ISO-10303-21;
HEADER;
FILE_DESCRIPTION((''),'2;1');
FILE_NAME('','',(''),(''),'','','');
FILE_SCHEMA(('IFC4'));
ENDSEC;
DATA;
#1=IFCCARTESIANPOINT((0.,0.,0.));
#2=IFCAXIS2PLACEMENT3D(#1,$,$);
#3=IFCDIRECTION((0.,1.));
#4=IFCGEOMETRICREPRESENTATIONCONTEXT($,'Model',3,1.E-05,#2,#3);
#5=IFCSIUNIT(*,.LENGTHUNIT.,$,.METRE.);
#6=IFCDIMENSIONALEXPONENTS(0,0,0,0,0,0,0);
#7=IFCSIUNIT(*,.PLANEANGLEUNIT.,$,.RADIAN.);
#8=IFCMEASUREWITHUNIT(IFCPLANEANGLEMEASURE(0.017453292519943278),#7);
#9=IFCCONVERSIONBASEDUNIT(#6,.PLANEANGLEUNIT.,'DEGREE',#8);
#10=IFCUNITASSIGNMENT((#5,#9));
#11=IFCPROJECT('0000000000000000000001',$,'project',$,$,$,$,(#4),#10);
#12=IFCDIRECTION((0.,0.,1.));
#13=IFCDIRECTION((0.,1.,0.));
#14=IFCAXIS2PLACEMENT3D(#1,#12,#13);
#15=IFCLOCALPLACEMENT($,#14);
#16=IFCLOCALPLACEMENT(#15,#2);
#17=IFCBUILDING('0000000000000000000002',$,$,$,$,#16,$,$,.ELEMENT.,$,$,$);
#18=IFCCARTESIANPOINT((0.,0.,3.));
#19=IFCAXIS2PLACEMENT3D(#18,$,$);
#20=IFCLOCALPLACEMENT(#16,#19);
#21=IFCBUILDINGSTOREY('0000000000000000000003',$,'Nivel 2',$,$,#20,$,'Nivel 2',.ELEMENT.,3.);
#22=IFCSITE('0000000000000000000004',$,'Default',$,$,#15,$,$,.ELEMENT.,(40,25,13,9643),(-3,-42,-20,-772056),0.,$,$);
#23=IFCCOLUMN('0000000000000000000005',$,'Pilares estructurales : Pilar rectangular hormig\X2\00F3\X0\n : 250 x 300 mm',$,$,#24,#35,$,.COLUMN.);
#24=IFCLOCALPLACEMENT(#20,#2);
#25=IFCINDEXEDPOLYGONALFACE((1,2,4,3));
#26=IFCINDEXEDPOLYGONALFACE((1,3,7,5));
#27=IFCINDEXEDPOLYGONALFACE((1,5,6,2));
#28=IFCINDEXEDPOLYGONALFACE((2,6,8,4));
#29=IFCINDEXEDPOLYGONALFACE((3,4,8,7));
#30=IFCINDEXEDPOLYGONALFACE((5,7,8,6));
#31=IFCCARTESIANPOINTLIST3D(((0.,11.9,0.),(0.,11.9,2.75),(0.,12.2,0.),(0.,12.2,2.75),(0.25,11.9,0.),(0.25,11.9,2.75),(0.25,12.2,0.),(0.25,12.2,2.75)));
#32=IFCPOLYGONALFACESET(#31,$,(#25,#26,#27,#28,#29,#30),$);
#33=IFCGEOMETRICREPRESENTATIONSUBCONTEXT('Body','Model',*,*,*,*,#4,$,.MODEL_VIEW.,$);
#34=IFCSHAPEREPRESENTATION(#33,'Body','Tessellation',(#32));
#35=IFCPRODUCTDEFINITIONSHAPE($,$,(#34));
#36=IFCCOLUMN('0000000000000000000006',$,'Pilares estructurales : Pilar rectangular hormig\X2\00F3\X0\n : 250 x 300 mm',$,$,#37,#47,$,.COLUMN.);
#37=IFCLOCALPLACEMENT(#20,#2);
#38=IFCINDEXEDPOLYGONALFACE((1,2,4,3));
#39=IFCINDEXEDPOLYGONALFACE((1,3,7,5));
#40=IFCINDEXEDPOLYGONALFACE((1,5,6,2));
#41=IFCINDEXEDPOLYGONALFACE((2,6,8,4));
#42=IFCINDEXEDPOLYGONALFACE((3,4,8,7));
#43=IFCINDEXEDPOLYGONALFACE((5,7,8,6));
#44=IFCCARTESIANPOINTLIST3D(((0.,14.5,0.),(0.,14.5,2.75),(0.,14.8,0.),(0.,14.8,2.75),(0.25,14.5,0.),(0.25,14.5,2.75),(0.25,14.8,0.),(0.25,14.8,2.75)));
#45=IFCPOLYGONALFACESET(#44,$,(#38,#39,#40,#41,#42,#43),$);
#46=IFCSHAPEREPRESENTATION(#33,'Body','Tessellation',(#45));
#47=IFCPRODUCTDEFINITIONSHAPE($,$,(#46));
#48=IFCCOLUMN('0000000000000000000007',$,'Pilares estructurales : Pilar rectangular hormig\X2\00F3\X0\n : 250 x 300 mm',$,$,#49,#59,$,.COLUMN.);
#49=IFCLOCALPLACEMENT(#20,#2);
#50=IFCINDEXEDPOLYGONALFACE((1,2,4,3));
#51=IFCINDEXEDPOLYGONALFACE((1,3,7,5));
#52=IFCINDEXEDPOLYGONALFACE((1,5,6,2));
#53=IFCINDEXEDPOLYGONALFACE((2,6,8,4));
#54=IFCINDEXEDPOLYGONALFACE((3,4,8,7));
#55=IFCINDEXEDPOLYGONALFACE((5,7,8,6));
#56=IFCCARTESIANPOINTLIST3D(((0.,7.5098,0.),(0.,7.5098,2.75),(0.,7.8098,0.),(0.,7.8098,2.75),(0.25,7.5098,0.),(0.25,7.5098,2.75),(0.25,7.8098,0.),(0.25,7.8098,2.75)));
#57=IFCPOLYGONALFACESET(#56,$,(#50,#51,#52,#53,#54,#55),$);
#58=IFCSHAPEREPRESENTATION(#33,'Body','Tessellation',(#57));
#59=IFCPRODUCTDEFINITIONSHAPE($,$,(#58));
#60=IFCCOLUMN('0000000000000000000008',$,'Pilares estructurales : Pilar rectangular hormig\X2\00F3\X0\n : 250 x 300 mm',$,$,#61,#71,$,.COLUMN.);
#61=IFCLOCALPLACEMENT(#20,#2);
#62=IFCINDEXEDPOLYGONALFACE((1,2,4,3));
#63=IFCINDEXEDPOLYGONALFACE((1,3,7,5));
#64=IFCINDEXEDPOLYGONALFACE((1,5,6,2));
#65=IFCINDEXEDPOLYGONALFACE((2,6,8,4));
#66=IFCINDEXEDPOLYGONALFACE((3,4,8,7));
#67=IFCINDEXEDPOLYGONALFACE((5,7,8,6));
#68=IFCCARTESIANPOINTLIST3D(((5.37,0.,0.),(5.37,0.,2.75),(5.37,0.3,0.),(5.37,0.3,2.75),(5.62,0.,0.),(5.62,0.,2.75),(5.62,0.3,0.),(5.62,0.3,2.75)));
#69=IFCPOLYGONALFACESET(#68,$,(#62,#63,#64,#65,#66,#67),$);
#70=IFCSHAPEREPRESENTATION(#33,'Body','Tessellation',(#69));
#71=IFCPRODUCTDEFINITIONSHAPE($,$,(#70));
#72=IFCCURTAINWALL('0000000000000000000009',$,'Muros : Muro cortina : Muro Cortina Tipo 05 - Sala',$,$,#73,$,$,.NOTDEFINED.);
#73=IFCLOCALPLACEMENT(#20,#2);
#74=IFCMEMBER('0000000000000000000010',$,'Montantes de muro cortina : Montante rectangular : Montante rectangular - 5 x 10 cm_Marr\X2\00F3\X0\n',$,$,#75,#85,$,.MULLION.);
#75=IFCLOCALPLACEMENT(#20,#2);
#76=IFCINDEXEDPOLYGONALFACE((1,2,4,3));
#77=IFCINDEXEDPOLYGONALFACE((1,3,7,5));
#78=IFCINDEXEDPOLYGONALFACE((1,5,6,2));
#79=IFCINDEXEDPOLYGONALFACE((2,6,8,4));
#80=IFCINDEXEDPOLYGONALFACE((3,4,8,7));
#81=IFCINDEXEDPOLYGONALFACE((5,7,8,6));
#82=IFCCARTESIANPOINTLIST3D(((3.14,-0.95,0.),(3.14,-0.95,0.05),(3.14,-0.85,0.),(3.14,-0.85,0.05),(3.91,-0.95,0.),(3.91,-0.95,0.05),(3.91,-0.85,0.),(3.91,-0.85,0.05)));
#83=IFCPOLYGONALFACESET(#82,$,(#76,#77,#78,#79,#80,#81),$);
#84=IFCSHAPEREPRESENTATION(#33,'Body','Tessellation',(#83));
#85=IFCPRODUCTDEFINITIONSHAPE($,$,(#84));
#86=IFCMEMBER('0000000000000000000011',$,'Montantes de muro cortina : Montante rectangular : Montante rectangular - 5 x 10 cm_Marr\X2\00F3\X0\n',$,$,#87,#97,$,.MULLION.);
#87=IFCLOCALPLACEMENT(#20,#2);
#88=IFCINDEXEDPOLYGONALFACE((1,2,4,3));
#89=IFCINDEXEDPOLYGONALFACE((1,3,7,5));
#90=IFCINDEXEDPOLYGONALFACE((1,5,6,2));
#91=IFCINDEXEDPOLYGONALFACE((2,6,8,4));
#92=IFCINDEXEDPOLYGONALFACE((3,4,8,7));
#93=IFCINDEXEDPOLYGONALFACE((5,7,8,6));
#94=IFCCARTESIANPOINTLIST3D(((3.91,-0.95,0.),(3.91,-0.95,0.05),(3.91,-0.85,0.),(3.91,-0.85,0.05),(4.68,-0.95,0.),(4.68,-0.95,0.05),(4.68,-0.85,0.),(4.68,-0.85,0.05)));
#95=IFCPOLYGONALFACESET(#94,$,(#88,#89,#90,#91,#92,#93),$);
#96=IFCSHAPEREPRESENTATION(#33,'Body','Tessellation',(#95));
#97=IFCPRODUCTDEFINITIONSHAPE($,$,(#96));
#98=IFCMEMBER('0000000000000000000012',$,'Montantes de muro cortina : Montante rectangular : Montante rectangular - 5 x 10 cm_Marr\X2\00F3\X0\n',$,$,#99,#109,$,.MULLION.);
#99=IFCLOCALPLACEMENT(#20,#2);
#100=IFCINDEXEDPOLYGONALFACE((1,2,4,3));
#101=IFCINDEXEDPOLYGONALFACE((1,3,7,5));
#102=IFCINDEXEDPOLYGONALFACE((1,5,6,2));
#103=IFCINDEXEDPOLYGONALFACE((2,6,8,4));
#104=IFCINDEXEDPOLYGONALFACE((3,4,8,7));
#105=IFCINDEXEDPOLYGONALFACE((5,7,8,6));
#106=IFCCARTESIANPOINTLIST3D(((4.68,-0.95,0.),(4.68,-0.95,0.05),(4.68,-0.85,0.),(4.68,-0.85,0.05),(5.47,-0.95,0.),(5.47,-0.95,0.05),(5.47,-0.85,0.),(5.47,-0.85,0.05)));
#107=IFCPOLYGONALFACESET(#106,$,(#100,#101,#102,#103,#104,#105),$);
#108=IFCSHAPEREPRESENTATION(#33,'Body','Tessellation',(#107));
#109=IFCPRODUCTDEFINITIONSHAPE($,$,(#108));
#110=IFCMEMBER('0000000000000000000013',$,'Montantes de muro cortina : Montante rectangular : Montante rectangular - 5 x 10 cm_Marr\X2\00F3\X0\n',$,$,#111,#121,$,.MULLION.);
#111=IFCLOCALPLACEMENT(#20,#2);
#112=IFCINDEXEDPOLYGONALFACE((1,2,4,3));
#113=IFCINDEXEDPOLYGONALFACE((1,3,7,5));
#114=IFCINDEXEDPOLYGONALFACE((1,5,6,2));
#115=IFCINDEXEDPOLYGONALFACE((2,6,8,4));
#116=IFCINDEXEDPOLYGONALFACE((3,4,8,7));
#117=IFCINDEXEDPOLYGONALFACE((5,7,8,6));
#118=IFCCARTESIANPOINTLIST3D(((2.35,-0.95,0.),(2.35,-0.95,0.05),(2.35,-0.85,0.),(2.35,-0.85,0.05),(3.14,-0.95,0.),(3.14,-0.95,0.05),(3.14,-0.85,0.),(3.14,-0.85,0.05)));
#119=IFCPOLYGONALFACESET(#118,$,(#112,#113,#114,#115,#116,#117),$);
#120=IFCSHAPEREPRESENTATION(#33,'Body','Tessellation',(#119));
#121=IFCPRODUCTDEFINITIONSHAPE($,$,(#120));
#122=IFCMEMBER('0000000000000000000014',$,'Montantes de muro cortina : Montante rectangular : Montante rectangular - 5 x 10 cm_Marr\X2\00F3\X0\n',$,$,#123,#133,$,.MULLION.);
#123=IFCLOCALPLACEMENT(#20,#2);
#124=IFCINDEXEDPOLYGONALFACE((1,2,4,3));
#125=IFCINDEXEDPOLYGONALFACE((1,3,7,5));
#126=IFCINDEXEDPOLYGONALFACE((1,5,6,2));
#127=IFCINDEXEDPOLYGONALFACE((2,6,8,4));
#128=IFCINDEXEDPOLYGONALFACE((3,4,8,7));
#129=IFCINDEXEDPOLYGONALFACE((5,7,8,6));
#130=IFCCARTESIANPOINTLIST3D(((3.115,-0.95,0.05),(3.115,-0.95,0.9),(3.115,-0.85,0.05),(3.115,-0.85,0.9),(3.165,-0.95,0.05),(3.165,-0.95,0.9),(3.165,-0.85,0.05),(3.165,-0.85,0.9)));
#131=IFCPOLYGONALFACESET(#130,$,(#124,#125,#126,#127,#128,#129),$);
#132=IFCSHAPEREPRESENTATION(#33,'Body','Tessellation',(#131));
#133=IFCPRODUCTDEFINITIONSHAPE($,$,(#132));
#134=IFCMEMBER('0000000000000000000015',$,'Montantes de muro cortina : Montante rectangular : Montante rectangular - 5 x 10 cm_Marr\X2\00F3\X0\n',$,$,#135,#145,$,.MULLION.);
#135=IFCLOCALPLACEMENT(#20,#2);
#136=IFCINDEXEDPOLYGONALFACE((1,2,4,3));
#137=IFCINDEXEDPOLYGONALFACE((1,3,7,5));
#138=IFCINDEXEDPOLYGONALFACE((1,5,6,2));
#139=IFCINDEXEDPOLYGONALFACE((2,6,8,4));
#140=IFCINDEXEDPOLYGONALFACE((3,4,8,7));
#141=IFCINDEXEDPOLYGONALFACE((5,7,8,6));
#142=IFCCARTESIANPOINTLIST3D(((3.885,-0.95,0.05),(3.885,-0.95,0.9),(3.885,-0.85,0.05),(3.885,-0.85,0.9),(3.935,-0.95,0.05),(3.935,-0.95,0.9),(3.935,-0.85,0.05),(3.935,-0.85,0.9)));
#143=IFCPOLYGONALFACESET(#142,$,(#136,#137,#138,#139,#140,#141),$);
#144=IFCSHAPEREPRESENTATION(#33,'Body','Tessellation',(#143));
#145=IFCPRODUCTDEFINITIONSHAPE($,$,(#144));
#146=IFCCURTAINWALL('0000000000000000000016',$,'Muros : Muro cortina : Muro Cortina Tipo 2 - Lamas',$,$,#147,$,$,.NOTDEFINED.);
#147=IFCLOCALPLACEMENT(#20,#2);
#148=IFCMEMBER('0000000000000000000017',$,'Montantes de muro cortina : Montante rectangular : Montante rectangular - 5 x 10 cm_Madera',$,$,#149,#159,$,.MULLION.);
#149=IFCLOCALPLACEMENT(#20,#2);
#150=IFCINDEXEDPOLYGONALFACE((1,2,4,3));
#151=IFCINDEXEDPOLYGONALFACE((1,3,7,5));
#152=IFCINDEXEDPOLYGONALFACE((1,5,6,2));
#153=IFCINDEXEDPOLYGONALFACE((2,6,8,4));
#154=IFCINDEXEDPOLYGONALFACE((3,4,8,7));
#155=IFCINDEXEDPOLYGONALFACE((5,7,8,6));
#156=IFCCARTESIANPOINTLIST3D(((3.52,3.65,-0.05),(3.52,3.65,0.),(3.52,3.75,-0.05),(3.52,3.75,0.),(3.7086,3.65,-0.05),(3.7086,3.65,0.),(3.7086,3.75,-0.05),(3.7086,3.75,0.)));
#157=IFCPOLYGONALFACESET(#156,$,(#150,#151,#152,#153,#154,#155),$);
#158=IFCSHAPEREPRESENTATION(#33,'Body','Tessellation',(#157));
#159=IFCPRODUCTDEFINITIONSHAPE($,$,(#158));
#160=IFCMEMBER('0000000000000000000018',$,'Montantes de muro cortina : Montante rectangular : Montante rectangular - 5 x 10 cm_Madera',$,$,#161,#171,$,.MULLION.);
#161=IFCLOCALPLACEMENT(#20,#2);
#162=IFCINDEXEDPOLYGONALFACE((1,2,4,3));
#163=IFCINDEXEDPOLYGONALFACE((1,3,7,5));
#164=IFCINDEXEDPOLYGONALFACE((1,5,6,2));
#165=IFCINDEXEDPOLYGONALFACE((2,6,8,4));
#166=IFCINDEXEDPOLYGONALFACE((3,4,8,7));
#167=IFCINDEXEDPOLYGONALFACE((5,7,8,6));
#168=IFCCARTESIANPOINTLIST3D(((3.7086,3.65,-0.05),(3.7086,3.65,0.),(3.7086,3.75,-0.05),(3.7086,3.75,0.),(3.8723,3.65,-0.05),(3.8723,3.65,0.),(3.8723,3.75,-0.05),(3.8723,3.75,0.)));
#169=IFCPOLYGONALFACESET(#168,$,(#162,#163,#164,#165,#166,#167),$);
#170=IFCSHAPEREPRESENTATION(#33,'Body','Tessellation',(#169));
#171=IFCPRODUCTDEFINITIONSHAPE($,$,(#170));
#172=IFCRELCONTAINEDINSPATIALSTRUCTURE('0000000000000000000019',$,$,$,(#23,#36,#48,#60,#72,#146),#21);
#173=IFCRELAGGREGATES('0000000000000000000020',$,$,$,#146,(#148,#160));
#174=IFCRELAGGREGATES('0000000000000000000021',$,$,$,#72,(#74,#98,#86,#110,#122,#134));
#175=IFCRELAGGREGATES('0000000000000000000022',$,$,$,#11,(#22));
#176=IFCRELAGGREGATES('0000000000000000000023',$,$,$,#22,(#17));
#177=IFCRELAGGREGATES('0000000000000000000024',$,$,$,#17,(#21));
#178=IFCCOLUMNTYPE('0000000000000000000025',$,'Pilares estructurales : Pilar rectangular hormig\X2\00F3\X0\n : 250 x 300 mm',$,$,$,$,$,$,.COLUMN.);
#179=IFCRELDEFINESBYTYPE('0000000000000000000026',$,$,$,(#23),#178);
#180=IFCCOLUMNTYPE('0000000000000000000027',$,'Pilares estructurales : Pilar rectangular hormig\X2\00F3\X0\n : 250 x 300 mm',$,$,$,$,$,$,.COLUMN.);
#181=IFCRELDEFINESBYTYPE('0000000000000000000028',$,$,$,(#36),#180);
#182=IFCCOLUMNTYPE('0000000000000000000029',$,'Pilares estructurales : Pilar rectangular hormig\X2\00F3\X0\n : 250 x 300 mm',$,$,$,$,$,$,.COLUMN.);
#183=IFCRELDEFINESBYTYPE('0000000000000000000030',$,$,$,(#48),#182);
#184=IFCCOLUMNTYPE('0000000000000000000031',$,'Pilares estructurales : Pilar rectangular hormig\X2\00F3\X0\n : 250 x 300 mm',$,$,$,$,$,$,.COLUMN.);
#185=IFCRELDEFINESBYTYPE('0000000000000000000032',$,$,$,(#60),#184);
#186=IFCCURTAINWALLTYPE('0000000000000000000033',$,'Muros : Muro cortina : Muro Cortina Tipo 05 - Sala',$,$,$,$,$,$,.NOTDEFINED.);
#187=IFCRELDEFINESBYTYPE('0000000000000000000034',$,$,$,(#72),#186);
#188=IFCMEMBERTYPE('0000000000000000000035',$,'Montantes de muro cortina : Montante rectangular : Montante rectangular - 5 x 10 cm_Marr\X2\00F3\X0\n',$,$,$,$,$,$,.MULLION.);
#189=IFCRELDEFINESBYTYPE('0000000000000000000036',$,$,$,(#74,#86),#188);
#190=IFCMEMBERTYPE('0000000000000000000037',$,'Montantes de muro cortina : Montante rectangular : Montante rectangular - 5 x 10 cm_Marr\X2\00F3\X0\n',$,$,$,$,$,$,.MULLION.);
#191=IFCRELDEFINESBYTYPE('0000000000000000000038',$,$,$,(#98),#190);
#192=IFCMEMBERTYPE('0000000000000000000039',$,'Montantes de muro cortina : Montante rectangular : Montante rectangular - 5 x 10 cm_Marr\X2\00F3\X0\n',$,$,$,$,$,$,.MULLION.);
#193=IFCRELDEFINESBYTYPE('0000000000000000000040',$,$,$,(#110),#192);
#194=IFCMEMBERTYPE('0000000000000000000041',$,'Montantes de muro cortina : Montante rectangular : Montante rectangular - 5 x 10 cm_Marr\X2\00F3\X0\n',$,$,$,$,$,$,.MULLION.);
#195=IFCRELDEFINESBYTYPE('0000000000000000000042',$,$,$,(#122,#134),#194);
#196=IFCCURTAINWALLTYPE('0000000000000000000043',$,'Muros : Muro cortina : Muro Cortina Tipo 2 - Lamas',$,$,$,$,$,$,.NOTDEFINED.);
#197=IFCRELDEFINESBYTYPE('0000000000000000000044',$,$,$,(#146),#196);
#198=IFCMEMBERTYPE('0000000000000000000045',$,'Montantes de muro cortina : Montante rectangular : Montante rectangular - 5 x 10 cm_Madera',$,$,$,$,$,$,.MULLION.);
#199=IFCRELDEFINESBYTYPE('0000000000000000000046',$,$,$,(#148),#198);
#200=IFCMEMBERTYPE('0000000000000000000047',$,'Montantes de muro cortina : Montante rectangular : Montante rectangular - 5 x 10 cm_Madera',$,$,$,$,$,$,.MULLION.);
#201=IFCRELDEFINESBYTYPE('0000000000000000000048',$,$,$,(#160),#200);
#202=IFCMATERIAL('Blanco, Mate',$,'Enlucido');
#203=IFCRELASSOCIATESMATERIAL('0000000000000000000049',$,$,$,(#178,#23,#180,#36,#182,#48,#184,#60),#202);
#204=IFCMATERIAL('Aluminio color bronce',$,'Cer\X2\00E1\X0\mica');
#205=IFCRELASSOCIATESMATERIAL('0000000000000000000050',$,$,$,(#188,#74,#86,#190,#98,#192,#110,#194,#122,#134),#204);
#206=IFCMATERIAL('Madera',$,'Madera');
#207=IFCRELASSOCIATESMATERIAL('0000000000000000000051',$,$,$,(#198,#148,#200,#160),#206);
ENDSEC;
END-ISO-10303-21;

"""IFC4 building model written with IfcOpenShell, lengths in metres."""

from ifc_helpers import new_model, entity, si_unit, converted_unit, direction, frame, origin, place, context, subcontext, project, spatial, indexed_curve, outline, extrude, source, transform, mapped, material, type_object, type_shapes, element, aggregate, save


model = new_model("IFC4")

# Units and contexts
model_context = context("Model", 3, precision=1e-05, world=origin(), true_north=direction((0.0, 1.0)))
body_context = subcontext(model_context, "Body", "Model", "MODEL_VIEW")
ifc_project = project(units=[si_unit("LENGTHUNIT", "METRE"), converted_unit("PLANEANGLEUNIT", "DEGREE", entity("IfcPlaneAngleMeasure", 0.017453292519943278), si_unit("PLANEANGLEUNIT", "RADIAN"), dimensions=[0, 0, 0, 0, 0, 0, 0])], contexts=[model_context])

# Site, building, storey
site_placement = place(None, frame((0.0, 0.0, 0.0), z_axis=(0.0, 0.0, 1.0), x_axis=(0.0, 1.0, 0.0)))
site = spatial("IfcSite", under=ifc_project, at=site_placement, Name="Default", CompositionType="ELEMENT", RefLatitude=(40, 25, 13, 9643), RefLongitude=(-3, -42, -20, -772056), RefElevation=0.0)
building_placement = place(site_placement, origin())
building = spatial("IfcBuilding", under=site, at=building_placement, CompositionType="ELEMENT")
storey_placement = place(building_placement, frame((0.0, 0.0, 3.0)))
storey = spatial("IfcBuildingStorey", under=building, at=storey_placement, Name="Nivel 2", LongName="Nivel 2", CompositionType="ELEMENT", Elevation=3.0)

# Columns
ifc_material_1 = material(Name="Blanco, Mate", Category="Enlucido")
column_type_1 = type_object("IfcColumnType", Name="Pilares estructurales : Pilar rectangular hormigón : 250 x 300 mm", PredefinedType="COLUMN", material=ifc_material_1)
shared_shape_1 = source(origin(), body_context, "Body", "SweptSolid", [
    extrude(outline(indexed_curve([(-1.375, -0.15), (1.375, -0.15), (1.375, 0.15), (-1.375, 0.15), (-1.375, -0.15)], self_intersect=False)), frame((0.0, 12.05, 4.375), z_axis=(1.0, 0.0, 0.0), x_axis=(0.0, 0.0, 1.0)), (0.0, 0.0, 1.0), 0.25),
])
type_shapes(column_type_1, [shared_shape_1])
column_1_placement = place(storey_placement, frame((0.0, 0.0, -3.0)))
element("IfcColumn", 1, at=column_1_placement, inside=storey, type_object=column_type_1, material=ifc_material_1, Name="Pilares estructurales : Pilar rectangular hormigón : 250 x 300 mm", PredefinedType="COLUMN", context=body_context, shape_type="MappedRepresentation", body=[
    mapped(shared_shape_1, transform((0.0, 0.0, 0.0), scale=1.0)),
])
column_type_2 = type_object("IfcColumnType", Name="Pilares estructurales : Pilar rectangular hormigón : 250 x 300 mm", PredefinedType="COLUMN", material=ifc_material_1)
shared_shape_2 = source(origin(), body_context, "Body", "SweptSolid", [
    extrude(outline(indexed_curve([(-1.375, -0.15), (1.375, -0.15), (1.375, 0.15), (-1.375, 0.15), (-1.375, -0.15)], self_intersect=False)), frame((0.0, 14.65, 4.375), z_axis=(1.0, 0.0, 0.0), x_axis=(0.0, 0.0, 1.0)), (0.0, 0.0, 1.0), 0.25),
])
type_shapes(column_type_2, [shared_shape_2])
column_2_placement = place(storey_placement, frame((0.0, 0.0, -3.0)))
element("IfcColumn", 2, at=column_2_placement, inside=storey, type_object=column_type_2, material=ifc_material_1, Name="Pilares estructurales : Pilar rectangular hormigón : 250 x 300 mm", PredefinedType="COLUMN", context=body_context, shape_type="MappedRepresentation", body=[
    mapped(shared_shape_2, transform((0.0, 0.0, 0.0), scale=1.0)),
])
column_type_3 = type_object("IfcColumnType", Name="Pilares estructurales : Pilar rectangular hormigón : 250 x 300 mm", PredefinedType="COLUMN", material=ifc_material_1)
shared_shape_3 = source(origin(), body_context, "Body", "SweptSolid", [
    extrude(outline(indexed_curve([(-1.375, -0.15), (1.375, -0.15), (1.375, 0.15), (-1.375, 0.15), (-1.375, -0.15)], self_intersect=False)), frame((0.0, 7.6598, 4.375), z_axis=(1.0, 0.0, 0.0), x_axis=(0.0, 0.0, 1.0)), (0.0, 0.0, 1.0), 0.25),
])
type_shapes(column_type_3, [shared_shape_3])
column_3_placement = place(storey_placement, frame((0.0, 0.0, -3.0)))
element("IfcColumn", 3, at=column_3_placement, inside=storey, type_object=column_type_3, material=ifc_material_1, Name="Pilares estructurales : Pilar rectangular hormigón : 250 x 300 mm", PredefinedType="COLUMN", context=body_context, shape_type="MappedRepresentation", body=[
    mapped(shared_shape_3, transform((0.0, 0.0, 0.0), scale=1.0)),
])
column_type_4 = type_object("IfcColumnType", Name="Pilares estructurales : Pilar rectangular hormigón : 250 x 300 mm", PredefinedType="COLUMN", material=ifc_material_1)
shared_shape_4 = source(origin(), body_context, "Body", "SweptSolid", [
    extrude(outline(indexed_curve([(-1.375, -0.15), (1.375, -0.15), (1.375, 0.15), (-1.375, 0.15), (-1.375, -0.15)], self_intersect=False)), frame((5.37, 0.15, 4.375), z_axis=(1.0, 0.0, 0.0), x_axis=(0.0, 0.0, 1.0)), (0.0, 0.0, 1.0), 0.25),
])
type_shapes(column_type_4, [shared_shape_4])
column_4_placement = place(storey_placement, frame((0.0, 0.0, -3.0)))
element("IfcColumn", 4, at=column_4_placement, inside=storey, type_object=column_type_4, material=ifc_material_1, Name="Pilares estructurales : Pilar rectangular hormigón : 250 x 300 mm", PredefinedType="COLUMN", context=body_context, shape_type="MappedRepresentation", body=[
    mapped(shared_shape_4, transform((0.0, 0.0, 0.0), scale=1.0)),
])

# Curtain walls, members
curtain_wall_type_1 = type_object("IfcCurtainWallType", Name="Muros : Muro cortina : Muro Cortina Tipo 05 - Sala", PredefinedType="NOTDEFINED")
curtain_wall_1_placement = place(storey_placement, frame((0.0, 0.0, -3.0)))
curtain_wall_1 = element("IfcCurtainWall", 5, at=curtain_wall_1_placement, inside=storey, type_object=curtain_wall_type_1, Name="Muros : Muro cortina : Muro Cortina Tipo 05 - Sala", PredefinedType="NOTDEFINED")
ifc_material_2 = material(Name="Aluminio color bronce", Category="Cerámica")
member_type_1 = type_object("IfcMemberType", Name="Montantes de muro cortina : Montante rectangular : Montante rectangular - 5 x 10 cm_Marrón", PredefinedType="MULLION", material=ifc_material_2)
shared_shape_5 = source(origin(), body_context, "Body", "SweptSolid", [
    extrude(outline(indexed_curve([(-0.025, -0.05), (0.025, -0.05), (0.025, 0.05), (-0.025, 0.05), (-0.025, -0.05)], self_intersect=False)), frame((-0.025, 0.0, -0.77)), (0.0, 0.0, 1.0), 0.77),
])
type_shapes(member_type_1, [shared_shape_5])
member_1_placement = place(curtain_wall_1_placement, frame((3.14, -0.9, 3.0), z_axis=(-1.0, 0.0, 0.0), x_axis=(0.0, 0.0, -1.0)))
member_1 = element("IfcMember", 6, at=member_1_placement, type_object=member_type_1, material=ifc_material_2, Name="Montantes de muro cortina : Montante rectangular : Montante rectangular - 5 x 10 cm_Marrón", PredefinedType="MULLION", context=body_context, shape_type="MappedRepresentation", body=[
    mapped(shared_shape_5, transform((0.0, 0.0, 0.0), scale=1.0)),
])
member_2_placement = place(curtain_wall_1_placement, frame((3.91, -0.9, 3.0), z_axis=(-1.0, 0.0, 0.0), x_axis=(0.0, 0.0, -1.0)))
member_2 = element("IfcMember", 7, at=member_2_placement, type_object=member_type_1, material=ifc_material_2, Name="Montantes de muro cortina : Montante rectangular : Montante rectangular - 5 x 10 cm_Marrón", PredefinedType="MULLION", context=body_context, shape_type="MappedRepresentation", body=[
    mapped(shared_shape_5, transform((0.0, 0.0, 0.0), scale=1.0)),
])
member_type_2 = type_object("IfcMemberType", Name="Montantes de muro cortina : Montante rectangular : Montante rectangular - 5 x 10 cm_Marrón", PredefinedType="MULLION", material=ifc_material_2)
shared_shape_6 = source(origin(), body_context, "Body", "SweptSolid", [
    extrude(outline(indexed_curve([(-0.025, -0.05), (0.025, -0.05), (0.025, 0.05), (-0.025, 0.05), (-0.025, -0.05)], self_intersect=False)), frame((-0.025, 0.0, -0.79)), (0.0, 0.0, 1.0), 0.79),
])
type_shapes(member_type_2, [shared_shape_6])
member_3_placement = place(curtain_wall_1_placement, frame((4.68, -0.9, 3.0), z_axis=(-1.0, 0.0, 0.0), x_axis=(0.0, 0.0, -1.0)))
member_3 = element("IfcMember", 8, at=member_3_placement, type_object=member_type_2, material=ifc_material_2, Name="Montantes de muro cortina : Montante rectangular : Montante rectangular - 5 x 10 cm_Marrón", PredefinedType="MULLION", context=body_context, shape_type="MappedRepresentation", body=[
    mapped(shared_shape_6, transform((0.0, 0.0, 0.0), scale=1.0)),
])
member_type_3 = type_object("IfcMemberType", Name="Montantes de muro cortina : Montante rectangular : Montante rectangular - 5 x 10 cm_Marrón", PredefinedType="MULLION", material=ifc_material_2)
shared_shape_7 = source(origin(), body_context, "Body", "SweptSolid", [
    extrude(outline(indexed_curve([(-0.025, -0.05), (0.025, -0.05), (0.025, 0.05), (-0.025, 0.05), (-0.025, -0.05)], self_intersect=False)), frame((-0.025, 0.0, -0.79)), (0.0, 0.0, 1.0), 0.79),
])
type_shapes(member_type_3, [shared_shape_7])
member_4_placement = place(curtain_wall_1_placement, frame((2.35, -0.9, 3.0), z_axis=(-1.0, 0.0, 0.0), x_axis=(0.0, 0.0, -1.0)))
member_4 = element("IfcMember", 9, at=member_4_placement, type_object=member_type_3, material=ifc_material_2, Name="Montantes de muro cortina : Montante rectangular : Montante rectangular - 5 x 10 cm_Marrón", PredefinedType="MULLION", context=body_context, shape_type="MappedRepresentation", body=[
    mapped(shared_shape_7, transform((0.0, 0.0, 0.0), scale=1.0)),
])
member_type_4 = type_object("IfcMemberType", Name="Montantes de muro cortina : Montante rectangular : Montante rectangular - 5 x 10 cm_Marrón", PredefinedType="MULLION", material=ifc_material_2)
shared_shape_8 = source(origin(), body_context, "Body", "SweptSolid", [
    extrude(outline(indexed_curve([(-0.05, -0.025), (0.05, -0.025), (0.05, 0.025), (-0.05, 0.025), (-0.05, -0.025)], self_intersect=False)), frame((0.0, 0.0, -0.85), z_axis=(0.0, 0.0, 1.0), x_axis=(0.0, 1.0, 0.0)), (0.0, 0.0, 1.0), 0.85),
])
type_shapes(member_type_4, [shared_shape_8])
member_5_placement = place(curtain_wall_1_placement, frame((3.14, -0.9, 3.05), z_axis=(0.0, 0.0, -1.0), x_axis=(1.0, 0.0, 0.0)))
member_5 = element("IfcMember", 10, at=member_5_placement, type_object=member_type_4, material=ifc_material_2, Name="Montantes de muro cortina : Montante rectangular : Montante rectangular - 5 x 10 cm_Marrón", PredefinedType="MULLION", context=body_context, shape_type="MappedRepresentation", body=[
    mapped(shared_shape_8, transform((0.0, 0.0, 0.0), scale=1.0)),
])
member_6_placement = place(curtain_wall_1_placement, frame((3.91, -0.9, 3.05), z_axis=(0.0, 0.0, -1.0), x_axis=(1.0, 0.0, 0.0)))
member_6 = element("IfcMember", 11, at=member_6_placement, type_object=member_type_4, material=ifc_material_2, Name="Montantes de muro cortina : Montante rectangular : Montante rectangular - 5 x 10 cm_Marrón", PredefinedType="MULLION", context=body_context, shape_type="MappedRepresentation", body=[
    mapped(shared_shape_8, transform((0.0, 0.0, 0.0), scale=1.0)),
])
curtain_wall_type_2 = type_object("IfcCurtainWallType", Name="Muros : Muro cortina : Muro Cortina Tipo 2 - Lamas", PredefinedType="NOTDEFINED")
curtain_wall_2_placement = place(storey_placement, frame((0.0, 0.0, -3.0)))
curtain_wall_2 = element("IfcCurtainWall", 12, at=curtain_wall_2_placement, inside=storey, type_object=curtain_wall_type_2, Name="Muros : Muro cortina : Muro Cortina Tipo 2 - Lamas", PredefinedType="NOTDEFINED")
ifc_material_3 = material(Name="Madera", Category="Madera")
member_type_5 = type_object("IfcMemberType", Name="Montantes de muro cortina : Montante rectangular : Montante rectangular - 5 x 10 cm_Madera", PredefinedType="MULLION", material=ifc_material_3)
shared_shape_9 = source(origin(), body_context, "Body", "SweptSolid", [
    extrude(outline(indexed_curve([(-0.0943, -0.05), (0.0943, -0.05), (0.0943, 0.05), (-0.0943, 0.05), (-0.0943, -0.05)], self_intersect=False)), frame((3.6143, 3.7, 2.95), z_axis=(0.0, 0.0, 1.0), x_axis=(-1.0, 0.0, 0.0)), (0.0, 0.0, 1.0), 0.05),
])
type_shapes(member_type_5, [shared_shape_9])
member_7_placement = place(curtain_wall_2_placement, origin())
member_7 = element("IfcMember", 13, at=member_7_placement, type_object=member_type_5, material=ifc_material_3, Name="Montantes de muro cortina : Montante rectangular : Montante rectangular - 5 x 10 cm_Madera", PredefinedType="MULLION", context=body_context, shape_type="MappedRepresentation", body=[
    mapped(shared_shape_9, transform((0.0, 0.0, 0.0), scale=1.0)),
])
member_type_6 = type_object("IfcMemberType", Name="Montantes de muro cortina : Montante rectangular : Montante rectangular - 5 x 10 cm_Madera", PredefinedType="MULLION", material=ifc_material_3)
shared_shape_10 = source(origin(), body_context, "Body", "SweptSolid", [
    extrude(outline(indexed_curve([(-0.0818, -0.05), (0.0818, -0.05), (0.0818, 0.05), (-0.0818, 0.05), (-0.0818, -0.05)], self_intersect=False)), frame((3.7905, 3.7, 2.95), z_axis=(0.0, 0.0, 1.0), x_axis=(-1.0, 0.0, 0.0)), (0.0, 0.0, 1.0), 0.05),
])
type_shapes(member_type_6, [shared_shape_10])
member_8_placement = place(curtain_wall_2_placement, origin())
member_8 = element("IfcMember", 14, at=member_8_placement, type_object=member_type_6, material=ifc_material_3, Name="Montantes de muro cortina : Montante rectangular : Montante rectangular - 5 x 10 cm_Madera", PredefinedType="MULLION", context=body_context, shape_type="MappedRepresentation", body=[
    mapped(shared_shape_10, transform((0.0, 0.0, 0.0), scale=1.0)),
])
aggregate(curtain_wall_2, [member_7, member_8])

aggregate(curtain_wall_1, [member_1, member_3, member_2, member_4, member_5, member_6])

save(model, "model.ifc")
